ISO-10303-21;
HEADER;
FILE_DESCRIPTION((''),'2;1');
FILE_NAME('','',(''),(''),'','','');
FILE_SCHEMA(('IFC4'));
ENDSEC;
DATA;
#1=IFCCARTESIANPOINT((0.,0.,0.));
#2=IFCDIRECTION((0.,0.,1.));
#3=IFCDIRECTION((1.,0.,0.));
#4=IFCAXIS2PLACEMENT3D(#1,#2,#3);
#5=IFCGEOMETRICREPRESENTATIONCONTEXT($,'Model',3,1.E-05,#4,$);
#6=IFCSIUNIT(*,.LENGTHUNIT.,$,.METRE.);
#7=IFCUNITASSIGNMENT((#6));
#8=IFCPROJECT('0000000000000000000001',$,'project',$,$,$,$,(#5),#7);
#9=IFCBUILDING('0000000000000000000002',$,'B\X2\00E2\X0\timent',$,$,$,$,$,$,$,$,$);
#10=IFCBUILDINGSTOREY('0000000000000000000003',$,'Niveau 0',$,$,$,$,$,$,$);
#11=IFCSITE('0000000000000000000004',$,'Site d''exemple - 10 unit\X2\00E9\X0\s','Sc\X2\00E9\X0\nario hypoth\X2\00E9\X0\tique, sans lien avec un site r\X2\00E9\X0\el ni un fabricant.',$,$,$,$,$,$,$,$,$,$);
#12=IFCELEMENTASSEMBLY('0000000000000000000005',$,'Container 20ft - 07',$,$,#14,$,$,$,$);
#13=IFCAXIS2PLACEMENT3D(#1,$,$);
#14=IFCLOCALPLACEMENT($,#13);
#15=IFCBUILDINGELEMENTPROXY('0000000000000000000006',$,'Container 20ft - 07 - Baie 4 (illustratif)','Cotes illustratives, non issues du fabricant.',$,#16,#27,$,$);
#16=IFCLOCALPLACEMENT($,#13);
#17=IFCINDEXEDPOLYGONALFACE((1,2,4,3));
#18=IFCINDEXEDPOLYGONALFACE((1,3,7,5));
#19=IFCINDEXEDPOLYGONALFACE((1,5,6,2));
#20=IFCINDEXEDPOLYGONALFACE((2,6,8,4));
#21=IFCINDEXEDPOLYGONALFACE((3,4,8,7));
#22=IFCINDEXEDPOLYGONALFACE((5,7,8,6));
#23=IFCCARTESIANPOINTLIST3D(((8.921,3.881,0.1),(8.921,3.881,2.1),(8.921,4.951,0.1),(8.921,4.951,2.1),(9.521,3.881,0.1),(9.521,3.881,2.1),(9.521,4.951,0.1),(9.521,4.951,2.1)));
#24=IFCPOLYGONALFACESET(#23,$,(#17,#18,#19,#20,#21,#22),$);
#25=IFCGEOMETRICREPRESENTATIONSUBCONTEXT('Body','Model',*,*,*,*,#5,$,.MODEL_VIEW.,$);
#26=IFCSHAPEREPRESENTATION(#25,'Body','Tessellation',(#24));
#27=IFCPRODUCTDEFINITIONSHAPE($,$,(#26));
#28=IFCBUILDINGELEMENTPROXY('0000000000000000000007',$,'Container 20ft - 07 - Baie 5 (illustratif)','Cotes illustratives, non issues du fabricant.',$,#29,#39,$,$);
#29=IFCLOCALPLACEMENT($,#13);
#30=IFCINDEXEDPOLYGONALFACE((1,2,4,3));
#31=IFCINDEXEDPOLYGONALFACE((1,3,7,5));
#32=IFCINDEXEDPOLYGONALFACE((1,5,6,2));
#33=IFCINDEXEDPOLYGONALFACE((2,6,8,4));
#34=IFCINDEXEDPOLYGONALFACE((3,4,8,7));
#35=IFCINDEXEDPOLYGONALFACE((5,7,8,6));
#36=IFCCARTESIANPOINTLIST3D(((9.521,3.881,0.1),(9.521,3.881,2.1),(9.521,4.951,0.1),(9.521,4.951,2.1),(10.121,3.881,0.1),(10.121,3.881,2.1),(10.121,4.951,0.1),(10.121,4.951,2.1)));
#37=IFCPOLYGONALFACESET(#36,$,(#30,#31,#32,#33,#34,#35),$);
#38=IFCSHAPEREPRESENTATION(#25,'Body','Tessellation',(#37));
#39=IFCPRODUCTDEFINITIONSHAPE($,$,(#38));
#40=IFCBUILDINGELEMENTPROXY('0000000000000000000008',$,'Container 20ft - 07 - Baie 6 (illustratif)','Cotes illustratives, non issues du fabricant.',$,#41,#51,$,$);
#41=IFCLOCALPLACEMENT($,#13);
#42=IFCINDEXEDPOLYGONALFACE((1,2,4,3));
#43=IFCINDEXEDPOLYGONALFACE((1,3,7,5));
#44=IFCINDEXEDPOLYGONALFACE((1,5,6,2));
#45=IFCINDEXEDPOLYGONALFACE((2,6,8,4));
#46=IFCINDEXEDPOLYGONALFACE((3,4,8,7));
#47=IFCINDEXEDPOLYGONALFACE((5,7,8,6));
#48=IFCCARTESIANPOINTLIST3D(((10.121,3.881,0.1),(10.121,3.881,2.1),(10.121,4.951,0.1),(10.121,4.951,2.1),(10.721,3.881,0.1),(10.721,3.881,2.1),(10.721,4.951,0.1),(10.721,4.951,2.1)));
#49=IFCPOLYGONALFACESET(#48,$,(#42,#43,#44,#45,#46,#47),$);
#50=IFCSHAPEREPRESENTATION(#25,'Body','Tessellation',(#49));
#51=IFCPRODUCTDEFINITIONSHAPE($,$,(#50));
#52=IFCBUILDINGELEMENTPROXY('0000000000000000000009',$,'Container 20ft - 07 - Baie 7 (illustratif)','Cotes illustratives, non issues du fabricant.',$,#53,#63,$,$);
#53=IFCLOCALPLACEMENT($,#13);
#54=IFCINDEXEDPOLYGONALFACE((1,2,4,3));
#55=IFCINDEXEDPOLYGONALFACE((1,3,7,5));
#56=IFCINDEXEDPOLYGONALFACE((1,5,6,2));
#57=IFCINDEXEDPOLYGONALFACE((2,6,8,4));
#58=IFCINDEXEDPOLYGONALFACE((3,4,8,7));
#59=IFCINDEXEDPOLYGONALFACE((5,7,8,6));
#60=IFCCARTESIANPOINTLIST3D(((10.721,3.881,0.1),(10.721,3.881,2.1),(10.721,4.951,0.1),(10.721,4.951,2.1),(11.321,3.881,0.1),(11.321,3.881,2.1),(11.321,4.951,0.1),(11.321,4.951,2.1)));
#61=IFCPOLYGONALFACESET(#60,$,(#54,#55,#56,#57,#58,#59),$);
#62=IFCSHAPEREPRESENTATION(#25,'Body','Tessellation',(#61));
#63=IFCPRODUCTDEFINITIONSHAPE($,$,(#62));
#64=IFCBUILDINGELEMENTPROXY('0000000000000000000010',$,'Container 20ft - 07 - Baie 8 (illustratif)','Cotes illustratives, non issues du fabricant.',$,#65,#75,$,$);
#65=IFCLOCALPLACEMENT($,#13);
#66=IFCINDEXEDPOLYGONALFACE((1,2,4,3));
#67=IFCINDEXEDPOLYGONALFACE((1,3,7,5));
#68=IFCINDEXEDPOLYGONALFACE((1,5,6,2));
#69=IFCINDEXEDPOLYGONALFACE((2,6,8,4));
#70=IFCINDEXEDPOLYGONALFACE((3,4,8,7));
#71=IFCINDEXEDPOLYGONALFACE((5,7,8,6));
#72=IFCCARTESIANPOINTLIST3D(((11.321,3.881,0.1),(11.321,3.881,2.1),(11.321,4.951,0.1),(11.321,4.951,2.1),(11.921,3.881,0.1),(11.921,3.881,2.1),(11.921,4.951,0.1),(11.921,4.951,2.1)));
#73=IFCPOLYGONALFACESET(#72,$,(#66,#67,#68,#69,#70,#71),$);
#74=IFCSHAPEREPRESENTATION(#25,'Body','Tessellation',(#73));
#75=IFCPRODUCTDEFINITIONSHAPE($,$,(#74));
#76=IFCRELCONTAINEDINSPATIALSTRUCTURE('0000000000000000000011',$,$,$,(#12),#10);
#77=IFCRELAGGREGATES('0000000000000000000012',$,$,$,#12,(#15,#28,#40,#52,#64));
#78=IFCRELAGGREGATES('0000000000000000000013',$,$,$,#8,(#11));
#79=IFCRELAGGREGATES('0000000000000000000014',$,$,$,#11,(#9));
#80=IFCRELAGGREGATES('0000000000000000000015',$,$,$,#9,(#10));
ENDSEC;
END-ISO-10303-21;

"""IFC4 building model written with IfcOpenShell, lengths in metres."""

from ifc_helpers import new_model, si_unit, frame, origin_with_axes, place, context, subcontext, project, spatial, rectangle, extrude, element, aggregate, save


model = new_model("IFC4")

# Units and contexts
model_context = context("Model", 3, precision=1e-05, world=origin_with_axes())
body_context = subcontext(model_context, "Body", "Model", "MODEL_VIEW")
ifc_project = project(units=[si_unit("LENGTHUNIT", "METRE")], contexts=[model_context])

# Site, building, storey
site = spatial("IfcSite", under=ifc_project, Name="Site d'exemple - 10 unités", Description="Scénario hypothétique, sans lien avec un site réel ni un fabricant.")
building = spatial("IfcBuilding", under=site, Name="Bâtiment")
storey = spatial("IfcBuildingStorey", under=building, Name="Niveau 0")

# Element assembly, building element proxies
assembly = element("IfcElementAssembly", 1, inside=storey, Name="Container 20ft - 07")
proxy_1_placement = place(None, frame((9.221, 4.416, 0.1), z_axis=(0.0, 0.0, 1.0), x_axis=(1.0, 0.0, 0.0)))
proxy_1 = element("IfcBuildingElementProxy", 2, at=proxy_1_placement, Name="Container 20ft - 07 - Baie 4 (illustratif)", Description="Cotes illustratives, non issues du fabricant.", context=body_context, shape_type="SweptSolid", body=[
    extrude(rectangle(XDim=0.6, YDim=1.07), origin_with_axes(), (0.0, 0.0, 1.0), 2.0),
])
proxy_2_placement = place(None, frame((9.821, 4.416, 0.1), z_axis=(0.0, 0.0, 1.0), x_axis=(1.0, 0.0, 0.0)))
proxy_2 = element("IfcBuildingElementProxy", 3, at=proxy_2_placement, Name="Container 20ft - 07 - Baie 5 (illustratif)", Description="Cotes illustratives, non issues du fabricant.", context=body_context, shape_type="SweptSolid", body=[
    extrude(rectangle(XDim=0.6, YDim=1.07), origin_with_axes(), (0.0, 0.0, 1.0), 2.0),
])
proxy_3_placement = place(None, frame((10.421, 4.416, 0.1), z_axis=(0.0, 0.0, 1.0), x_axis=(1.0, 0.0, 0.0)))
proxy_3 = element("IfcBuildingElementProxy", 4, at=proxy_3_placement, Name="Container 20ft - 07 - Baie 6 (illustratif)", Description="Cotes illustratives, non issues du fabricant.", context=body_context, shape_type="SweptSolid", body=[
    extrude(rectangle(XDim=0.6, YDim=1.07), origin_with_axes(), (0.0, 0.0, 1.0), 2.0),
])
proxy_4_placement = place(None, frame((11.021, 4.416, 0.1), z_axis=(0.0, 0.0, 1.0), x_axis=(1.0, 0.0, 0.0)))
proxy_4 = element("IfcBuildingElementProxy", 5, at=proxy_4_placement, Name="Container 20ft - 07 - Baie 7 (illustratif)", Description="Cotes illustratives, non issues du fabricant.", context=body_context, shape_type="SweptSolid", body=[
    extrude(rectangle(XDim=0.6, YDim=1.07), origin_with_axes(), (0.0, 0.0, 1.0), 2.0),
])
proxy_5_placement = place(None, frame((11.621, 4.416, 0.1), z_axis=(0.0, 0.0, 1.0), x_axis=(1.0, 0.0, 0.0)))
proxy_5 = element("IfcBuildingElementProxy", 6, at=proxy_5_placement, Name="Container 20ft - 07 - Baie 8 (illustratif)", Description="Cotes illustratives, non issues du fabricant.", context=body_context, shape_type="SweptSolid", body=[
    extrude(rectangle(XDim=0.6, YDim=1.07), origin_with_axes(), (0.0, 0.0, 1.0), 2.0),
])
aggregate(assembly, [proxy_1, proxy_2, proxy_3, proxy_4, proxy_5])

save(model, "model.ifc")
